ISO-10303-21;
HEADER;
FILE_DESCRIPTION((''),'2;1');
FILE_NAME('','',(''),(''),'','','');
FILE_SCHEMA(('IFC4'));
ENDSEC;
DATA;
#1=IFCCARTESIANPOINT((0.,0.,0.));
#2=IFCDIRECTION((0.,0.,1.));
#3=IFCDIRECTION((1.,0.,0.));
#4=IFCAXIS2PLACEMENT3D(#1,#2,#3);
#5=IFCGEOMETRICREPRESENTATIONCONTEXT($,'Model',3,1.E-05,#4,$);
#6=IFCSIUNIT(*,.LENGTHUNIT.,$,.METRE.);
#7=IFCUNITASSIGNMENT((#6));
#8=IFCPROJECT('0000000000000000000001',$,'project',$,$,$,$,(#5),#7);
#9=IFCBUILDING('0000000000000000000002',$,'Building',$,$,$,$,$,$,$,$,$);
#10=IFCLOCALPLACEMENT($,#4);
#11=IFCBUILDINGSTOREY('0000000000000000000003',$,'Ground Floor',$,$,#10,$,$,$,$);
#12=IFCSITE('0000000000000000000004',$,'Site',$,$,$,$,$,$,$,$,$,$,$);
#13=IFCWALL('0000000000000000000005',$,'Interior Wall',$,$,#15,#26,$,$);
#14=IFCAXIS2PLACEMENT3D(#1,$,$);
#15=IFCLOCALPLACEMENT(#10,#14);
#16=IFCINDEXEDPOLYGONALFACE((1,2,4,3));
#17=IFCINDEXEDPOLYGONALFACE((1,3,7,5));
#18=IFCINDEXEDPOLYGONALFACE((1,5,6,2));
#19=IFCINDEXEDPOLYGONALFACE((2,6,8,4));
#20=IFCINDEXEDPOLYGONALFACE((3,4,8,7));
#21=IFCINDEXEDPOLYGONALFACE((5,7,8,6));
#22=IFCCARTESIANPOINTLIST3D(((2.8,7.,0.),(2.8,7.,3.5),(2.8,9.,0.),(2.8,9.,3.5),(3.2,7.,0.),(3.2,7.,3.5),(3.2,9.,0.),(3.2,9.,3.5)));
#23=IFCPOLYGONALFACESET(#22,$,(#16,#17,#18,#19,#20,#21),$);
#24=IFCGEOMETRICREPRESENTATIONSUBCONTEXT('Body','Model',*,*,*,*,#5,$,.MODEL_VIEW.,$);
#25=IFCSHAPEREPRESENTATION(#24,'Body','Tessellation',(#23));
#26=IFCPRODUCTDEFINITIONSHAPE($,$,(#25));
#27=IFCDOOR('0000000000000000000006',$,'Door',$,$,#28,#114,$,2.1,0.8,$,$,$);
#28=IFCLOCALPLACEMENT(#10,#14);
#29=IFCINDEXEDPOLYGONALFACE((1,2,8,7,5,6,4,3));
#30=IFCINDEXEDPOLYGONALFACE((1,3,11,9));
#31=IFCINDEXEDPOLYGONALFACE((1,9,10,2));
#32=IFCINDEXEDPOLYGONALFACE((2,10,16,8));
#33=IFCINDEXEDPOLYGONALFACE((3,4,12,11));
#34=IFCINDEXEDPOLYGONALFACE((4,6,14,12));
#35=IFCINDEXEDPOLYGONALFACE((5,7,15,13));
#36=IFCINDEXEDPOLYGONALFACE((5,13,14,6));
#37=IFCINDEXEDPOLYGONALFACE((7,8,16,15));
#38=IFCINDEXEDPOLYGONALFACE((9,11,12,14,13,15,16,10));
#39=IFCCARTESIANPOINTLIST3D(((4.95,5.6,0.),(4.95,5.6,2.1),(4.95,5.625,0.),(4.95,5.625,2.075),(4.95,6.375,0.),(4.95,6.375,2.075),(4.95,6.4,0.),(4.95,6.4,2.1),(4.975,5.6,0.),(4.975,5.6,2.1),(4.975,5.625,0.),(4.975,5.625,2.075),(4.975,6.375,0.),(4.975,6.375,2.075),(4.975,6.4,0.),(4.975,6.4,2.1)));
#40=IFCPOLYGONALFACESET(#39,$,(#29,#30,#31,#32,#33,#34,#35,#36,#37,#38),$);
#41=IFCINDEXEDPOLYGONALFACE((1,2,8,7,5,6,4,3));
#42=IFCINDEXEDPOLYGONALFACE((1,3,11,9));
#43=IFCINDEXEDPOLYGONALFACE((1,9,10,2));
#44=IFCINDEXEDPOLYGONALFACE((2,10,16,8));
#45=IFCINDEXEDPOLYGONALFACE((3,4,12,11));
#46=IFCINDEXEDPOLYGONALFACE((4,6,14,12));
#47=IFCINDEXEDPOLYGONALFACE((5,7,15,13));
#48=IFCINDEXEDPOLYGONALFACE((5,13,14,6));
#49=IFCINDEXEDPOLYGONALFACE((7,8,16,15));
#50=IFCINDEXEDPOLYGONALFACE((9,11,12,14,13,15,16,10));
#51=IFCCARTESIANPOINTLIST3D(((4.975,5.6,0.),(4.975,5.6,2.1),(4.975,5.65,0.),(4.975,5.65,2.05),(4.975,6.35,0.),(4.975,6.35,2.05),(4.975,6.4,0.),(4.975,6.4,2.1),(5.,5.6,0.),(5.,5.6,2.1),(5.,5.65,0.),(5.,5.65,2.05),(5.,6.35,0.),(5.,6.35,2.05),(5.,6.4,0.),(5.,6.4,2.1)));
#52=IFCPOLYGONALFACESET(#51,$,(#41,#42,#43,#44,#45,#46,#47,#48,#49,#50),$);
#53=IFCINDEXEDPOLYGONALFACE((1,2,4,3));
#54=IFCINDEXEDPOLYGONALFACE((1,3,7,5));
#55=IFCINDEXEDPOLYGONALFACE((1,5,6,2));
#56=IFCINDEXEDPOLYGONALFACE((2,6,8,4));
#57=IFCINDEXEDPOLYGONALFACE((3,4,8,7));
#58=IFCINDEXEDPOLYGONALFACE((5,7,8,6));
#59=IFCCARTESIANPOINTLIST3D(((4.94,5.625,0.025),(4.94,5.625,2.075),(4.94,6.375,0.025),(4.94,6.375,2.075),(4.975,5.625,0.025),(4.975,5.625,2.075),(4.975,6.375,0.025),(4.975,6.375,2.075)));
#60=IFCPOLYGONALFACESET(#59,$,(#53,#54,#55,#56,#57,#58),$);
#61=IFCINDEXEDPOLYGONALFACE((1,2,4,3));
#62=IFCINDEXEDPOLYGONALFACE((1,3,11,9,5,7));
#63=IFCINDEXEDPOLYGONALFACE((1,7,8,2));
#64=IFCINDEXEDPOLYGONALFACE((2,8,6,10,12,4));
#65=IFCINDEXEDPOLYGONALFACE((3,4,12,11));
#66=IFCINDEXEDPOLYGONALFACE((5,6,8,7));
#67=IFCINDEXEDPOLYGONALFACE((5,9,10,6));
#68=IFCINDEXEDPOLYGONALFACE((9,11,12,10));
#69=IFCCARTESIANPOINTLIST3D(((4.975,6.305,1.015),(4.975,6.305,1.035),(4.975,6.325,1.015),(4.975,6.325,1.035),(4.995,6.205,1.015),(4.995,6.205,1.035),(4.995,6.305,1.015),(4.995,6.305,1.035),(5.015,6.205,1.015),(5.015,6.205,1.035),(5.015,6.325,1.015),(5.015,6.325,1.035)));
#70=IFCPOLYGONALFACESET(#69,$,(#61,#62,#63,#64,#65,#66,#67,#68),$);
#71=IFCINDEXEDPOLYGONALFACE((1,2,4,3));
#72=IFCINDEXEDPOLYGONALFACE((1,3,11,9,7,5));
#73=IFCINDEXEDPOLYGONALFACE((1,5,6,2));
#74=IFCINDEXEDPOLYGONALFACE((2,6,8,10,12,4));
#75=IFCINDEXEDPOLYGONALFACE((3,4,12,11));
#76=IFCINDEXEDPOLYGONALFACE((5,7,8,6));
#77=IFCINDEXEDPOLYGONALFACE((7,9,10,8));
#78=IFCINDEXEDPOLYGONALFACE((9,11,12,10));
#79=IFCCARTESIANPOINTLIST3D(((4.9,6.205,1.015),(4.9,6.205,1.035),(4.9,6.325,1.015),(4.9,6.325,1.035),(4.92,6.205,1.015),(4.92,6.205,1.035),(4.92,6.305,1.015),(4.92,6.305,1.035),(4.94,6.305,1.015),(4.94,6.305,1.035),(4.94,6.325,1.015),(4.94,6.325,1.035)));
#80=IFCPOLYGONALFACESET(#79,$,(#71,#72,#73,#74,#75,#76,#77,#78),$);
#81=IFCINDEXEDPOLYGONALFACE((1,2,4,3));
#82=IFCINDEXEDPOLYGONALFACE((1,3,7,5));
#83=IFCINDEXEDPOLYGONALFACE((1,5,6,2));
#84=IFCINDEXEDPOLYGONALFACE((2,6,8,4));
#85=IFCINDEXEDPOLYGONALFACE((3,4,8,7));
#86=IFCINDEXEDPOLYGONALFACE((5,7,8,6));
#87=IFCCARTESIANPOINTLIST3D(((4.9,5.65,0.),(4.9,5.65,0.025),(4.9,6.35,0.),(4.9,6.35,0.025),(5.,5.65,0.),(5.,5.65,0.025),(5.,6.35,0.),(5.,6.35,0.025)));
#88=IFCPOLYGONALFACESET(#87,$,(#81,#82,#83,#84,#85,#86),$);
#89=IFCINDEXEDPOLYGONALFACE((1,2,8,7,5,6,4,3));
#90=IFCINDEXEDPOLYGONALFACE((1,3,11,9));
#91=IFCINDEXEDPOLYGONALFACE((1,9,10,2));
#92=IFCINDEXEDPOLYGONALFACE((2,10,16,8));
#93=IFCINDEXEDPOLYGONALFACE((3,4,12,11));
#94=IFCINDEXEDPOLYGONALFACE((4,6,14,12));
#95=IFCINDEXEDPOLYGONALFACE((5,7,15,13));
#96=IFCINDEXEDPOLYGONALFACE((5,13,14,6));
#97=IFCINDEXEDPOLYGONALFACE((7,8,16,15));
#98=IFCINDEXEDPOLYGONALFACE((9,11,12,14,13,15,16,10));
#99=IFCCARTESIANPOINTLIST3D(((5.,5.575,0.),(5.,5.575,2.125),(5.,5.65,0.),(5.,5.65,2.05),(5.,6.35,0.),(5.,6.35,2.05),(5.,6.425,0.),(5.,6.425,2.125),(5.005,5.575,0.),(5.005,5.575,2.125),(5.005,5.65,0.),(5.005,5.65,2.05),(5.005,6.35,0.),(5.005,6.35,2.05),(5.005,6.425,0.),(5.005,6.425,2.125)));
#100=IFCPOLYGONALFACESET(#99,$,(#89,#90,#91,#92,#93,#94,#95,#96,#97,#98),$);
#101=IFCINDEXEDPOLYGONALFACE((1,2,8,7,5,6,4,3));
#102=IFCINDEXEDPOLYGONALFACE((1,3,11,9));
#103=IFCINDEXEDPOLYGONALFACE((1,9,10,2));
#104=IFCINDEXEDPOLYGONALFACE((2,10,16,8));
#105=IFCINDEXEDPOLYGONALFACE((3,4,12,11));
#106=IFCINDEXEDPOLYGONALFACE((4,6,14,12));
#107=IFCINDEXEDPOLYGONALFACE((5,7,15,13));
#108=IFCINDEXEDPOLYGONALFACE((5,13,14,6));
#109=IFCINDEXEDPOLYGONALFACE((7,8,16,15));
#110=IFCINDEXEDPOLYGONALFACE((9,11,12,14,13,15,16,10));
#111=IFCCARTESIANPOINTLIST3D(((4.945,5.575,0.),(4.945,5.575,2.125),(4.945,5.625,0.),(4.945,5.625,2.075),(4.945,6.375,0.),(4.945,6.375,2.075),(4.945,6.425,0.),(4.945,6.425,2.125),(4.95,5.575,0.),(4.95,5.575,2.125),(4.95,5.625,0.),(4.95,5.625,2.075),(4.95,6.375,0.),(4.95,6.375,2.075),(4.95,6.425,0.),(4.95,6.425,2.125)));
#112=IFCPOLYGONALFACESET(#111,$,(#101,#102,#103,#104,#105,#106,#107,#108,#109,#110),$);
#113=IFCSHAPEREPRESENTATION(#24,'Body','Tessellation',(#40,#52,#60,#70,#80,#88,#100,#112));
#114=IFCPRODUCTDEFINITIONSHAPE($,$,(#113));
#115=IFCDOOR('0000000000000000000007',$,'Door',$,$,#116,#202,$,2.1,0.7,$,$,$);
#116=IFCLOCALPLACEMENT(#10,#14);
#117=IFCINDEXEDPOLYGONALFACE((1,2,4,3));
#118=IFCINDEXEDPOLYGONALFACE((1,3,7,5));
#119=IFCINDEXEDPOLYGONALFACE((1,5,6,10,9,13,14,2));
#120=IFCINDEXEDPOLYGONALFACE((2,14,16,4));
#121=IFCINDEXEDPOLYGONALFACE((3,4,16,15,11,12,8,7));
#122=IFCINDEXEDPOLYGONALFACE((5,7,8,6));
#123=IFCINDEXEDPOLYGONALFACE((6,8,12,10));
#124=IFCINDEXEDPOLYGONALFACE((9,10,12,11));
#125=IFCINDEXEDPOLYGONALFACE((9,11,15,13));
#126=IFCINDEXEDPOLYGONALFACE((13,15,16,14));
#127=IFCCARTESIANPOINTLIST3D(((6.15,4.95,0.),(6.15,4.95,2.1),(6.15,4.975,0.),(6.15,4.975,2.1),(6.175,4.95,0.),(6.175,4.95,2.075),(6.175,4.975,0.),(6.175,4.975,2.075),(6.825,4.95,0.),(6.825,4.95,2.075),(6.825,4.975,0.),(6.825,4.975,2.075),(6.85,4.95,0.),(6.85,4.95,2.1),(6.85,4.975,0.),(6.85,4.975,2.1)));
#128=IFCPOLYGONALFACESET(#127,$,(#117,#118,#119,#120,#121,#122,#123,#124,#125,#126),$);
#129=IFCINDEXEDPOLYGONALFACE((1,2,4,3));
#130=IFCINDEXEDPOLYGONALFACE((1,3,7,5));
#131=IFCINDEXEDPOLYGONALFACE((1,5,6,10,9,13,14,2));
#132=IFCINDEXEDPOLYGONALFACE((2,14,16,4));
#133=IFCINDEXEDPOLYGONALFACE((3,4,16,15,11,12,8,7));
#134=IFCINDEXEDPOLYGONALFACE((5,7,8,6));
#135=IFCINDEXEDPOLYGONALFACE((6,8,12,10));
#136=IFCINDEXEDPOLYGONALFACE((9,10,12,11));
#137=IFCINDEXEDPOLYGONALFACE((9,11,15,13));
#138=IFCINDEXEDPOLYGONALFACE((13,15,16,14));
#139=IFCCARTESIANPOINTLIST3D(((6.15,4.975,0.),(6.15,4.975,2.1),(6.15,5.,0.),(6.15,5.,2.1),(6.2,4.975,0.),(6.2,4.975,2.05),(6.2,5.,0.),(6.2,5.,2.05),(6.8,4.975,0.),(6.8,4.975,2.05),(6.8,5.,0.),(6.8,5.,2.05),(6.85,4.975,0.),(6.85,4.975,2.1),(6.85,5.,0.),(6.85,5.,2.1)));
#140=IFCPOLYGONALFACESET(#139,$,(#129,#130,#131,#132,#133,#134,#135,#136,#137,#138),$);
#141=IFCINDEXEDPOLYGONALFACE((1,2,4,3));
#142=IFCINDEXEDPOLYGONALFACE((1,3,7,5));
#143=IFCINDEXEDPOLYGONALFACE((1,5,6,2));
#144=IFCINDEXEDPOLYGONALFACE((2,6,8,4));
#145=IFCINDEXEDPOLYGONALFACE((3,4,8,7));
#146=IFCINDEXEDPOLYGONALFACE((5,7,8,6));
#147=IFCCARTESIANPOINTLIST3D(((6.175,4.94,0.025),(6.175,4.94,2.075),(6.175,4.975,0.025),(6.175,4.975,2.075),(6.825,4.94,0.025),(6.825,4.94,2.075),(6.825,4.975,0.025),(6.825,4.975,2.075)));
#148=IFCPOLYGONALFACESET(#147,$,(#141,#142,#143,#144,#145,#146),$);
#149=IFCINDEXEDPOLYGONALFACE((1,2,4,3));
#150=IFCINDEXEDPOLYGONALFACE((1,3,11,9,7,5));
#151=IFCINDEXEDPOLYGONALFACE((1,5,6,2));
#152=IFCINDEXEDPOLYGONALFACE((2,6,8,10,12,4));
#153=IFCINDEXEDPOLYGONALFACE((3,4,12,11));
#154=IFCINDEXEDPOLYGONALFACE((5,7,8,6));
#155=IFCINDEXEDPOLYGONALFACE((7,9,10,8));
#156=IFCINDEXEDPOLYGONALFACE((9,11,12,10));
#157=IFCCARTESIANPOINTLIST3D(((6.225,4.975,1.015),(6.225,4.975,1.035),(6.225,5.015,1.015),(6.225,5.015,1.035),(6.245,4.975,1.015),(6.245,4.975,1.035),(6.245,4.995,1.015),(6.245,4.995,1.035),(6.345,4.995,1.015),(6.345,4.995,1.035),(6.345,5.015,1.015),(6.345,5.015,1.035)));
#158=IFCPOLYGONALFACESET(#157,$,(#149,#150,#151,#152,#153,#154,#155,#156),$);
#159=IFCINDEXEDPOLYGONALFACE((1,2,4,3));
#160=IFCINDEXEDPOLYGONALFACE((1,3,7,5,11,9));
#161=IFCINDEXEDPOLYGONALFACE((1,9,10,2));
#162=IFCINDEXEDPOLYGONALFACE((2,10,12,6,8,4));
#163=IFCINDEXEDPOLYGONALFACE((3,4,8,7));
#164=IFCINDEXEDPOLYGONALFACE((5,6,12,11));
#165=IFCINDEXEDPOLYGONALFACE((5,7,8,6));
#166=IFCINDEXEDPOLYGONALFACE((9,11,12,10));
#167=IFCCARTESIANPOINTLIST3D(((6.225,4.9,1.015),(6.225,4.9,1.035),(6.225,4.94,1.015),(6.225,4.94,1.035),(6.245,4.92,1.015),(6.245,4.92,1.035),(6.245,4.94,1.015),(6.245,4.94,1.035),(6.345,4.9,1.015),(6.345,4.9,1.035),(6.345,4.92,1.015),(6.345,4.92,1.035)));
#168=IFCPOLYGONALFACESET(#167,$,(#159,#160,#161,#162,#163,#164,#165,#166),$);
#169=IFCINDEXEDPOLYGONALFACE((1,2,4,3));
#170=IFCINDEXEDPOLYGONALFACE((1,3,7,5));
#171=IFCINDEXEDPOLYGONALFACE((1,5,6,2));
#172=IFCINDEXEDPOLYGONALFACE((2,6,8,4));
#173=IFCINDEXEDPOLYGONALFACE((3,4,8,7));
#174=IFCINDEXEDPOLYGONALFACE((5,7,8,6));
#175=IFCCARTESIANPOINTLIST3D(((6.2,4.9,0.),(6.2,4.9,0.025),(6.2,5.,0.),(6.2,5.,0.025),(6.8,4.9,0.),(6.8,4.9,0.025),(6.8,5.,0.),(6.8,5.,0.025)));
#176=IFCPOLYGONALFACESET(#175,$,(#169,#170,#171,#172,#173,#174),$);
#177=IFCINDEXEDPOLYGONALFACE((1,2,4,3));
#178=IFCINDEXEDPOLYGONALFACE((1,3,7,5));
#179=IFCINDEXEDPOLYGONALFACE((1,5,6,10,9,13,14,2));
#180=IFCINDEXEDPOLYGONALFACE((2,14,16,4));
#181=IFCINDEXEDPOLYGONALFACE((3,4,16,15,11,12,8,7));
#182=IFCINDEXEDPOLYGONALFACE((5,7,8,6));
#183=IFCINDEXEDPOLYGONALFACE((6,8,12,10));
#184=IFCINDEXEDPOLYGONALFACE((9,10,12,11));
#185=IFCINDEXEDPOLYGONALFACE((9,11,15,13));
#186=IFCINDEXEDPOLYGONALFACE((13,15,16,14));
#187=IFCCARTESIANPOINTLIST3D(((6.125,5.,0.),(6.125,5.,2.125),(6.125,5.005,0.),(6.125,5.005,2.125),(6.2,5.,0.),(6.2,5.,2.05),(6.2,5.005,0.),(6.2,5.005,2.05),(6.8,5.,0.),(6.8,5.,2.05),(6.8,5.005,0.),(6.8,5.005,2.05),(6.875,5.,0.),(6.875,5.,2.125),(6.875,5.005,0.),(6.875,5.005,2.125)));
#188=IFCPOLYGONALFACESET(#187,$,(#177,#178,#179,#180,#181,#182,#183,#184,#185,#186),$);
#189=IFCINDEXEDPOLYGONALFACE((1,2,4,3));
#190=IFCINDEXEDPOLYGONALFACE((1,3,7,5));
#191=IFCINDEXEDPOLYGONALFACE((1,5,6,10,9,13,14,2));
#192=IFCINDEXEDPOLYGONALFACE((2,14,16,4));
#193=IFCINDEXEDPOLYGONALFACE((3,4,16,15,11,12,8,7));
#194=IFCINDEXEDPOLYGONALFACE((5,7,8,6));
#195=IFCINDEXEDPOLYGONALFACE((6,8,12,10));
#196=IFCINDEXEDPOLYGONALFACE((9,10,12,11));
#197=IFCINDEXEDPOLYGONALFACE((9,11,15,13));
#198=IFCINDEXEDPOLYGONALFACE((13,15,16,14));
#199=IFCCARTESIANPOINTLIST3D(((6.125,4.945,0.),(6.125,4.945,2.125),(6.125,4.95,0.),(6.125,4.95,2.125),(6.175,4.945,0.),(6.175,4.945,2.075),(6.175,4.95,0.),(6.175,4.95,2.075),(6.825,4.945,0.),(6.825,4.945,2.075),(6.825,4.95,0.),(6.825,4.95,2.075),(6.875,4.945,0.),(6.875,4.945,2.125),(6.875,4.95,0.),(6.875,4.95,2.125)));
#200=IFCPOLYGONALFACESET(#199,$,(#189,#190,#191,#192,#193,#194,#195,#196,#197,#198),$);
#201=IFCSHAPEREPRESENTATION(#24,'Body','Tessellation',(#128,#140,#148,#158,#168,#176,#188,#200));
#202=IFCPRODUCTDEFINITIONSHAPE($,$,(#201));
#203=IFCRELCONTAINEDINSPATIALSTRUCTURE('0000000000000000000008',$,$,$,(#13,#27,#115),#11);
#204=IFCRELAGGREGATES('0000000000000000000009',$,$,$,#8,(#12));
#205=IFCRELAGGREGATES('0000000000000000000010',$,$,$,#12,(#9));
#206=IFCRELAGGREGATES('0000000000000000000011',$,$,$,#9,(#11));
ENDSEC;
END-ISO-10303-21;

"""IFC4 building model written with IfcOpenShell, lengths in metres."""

from ifc_helpers import new_model, si_unit, frame, origin_with_axes, place, context, subcontext, project, spatial, line, indexed_curve, outline, extrude, element, save


model = new_model("IFC4")

# Units and contexts
model_context = context("Model", 3, precision=1e-05, world=origin_with_axes())
body_context = subcontext(model_context, "Body", "Model", "MODEL_VIEW")
ifc_project = project(units=[si_unit("LENGTHUNIT", "METRE")], contexts=[model_context])

# Site, building, storey
site = spatial("IfcSite", under=ifc_project, Name="Site")
building = spatial("IfcBuilding", under=site, Name="Building")
storey_placement = place(None, origin_with_axes())
storey = spatial("IfcBuildingStorey", under=building, at=storey_placement, Name="Ground Floor")

# Wall
wall_1_placement = place(storey_placement, frame((3.0, 7.0, 0.0), z_axis=(0.0, 0.0, 1.0), x_axis=(0.0, 1.0, 0.0)))
element("IfcWall", 1, at=wall_1_placement, inside=storey, Name="Interior Wall", context=body_context, shape_type="SweptSolid", body=[
    extrude(outline(indexed_curve([(0.0, 0.0), (0.0, 0.4), (2.0, 0.4), (2.0, 0.0), (0.0, 0.0)], self_intersect=False)), frame((0.0, -0.2, 0.0), z_axis=(0.0, 0.0, 1.0), x_axis=(1.0, 0.0, 0.0)), (0.0, 0.0, 1.0), 3.5),
])

# Doors
door_1_placement = place(storey_placement, frame((5.0, 5.6, 0.0), z_axis=(0.0, 0.0, 1.0), x_axis=(0.0, 1.0, 0.0)))
element("IfcDoor", 2, at=door_1_placement, inside=storey, Name="Door", OverallHeight=2.1, OverallWidth=0.8, context=body_context, shape_type="SweptSolid", body=[
    extrude(outline(indexed_curve([(0.0, 0.0), (0.0, 2.1), (0.8, 2.1), (0.8, 0.0), (0.775, 0.0), (0.775, 2.075), (0.025, 2.075), (0.025, 0.0)], segments=[line(1, 2, 3, 4, 5, 6, 7, 8, 1)])), frame((0.0, 0.025, 0.0), z_axis=(0.0, -1.0, 0.0), x_axis=(1.0, 0.0, 0.0)), (0.0, 0.0, -1.0), 0.025),
    extrude(outline(indexed_curve([(0.0, 0.0), (0.0, 2.1), (0.8, 2.1), (0.8, 0.0), (0.75, 0.0), (0.75, 2.05), (0.05, 2.05), (0.05, 0.0)], segments=[line(1, 2, 3, 4, 5, 6, 7, 8, 1)])), frame((0.0, 0.0, 0.0), z_axis=(0.0, -1.0, 0.0), x_axis=(1.0, 0.0, 0.0)), (0.0, 0.0, -1.0), 0.025),
    extrude(outline(indexed_curve([(0.0, 0.0), (0.75, 0.0), (0.75, 0.035), (0.0, 0.035)], segments=[line(1, 2, 3, 4, 1)])), frame((0.025, 0.025, 0.025), z_axis=(0.0, 0.0, 1.0), x_axis=(1.0, 0.0, 0.0)), (0.0, 0.0, 1.0), 2.05),
    extrude(outline(indexed_curve([(0.0, 0.0), (0.0, -0.04), (-0.12, -0.04), (-0.12, -0.02), (-0.02, -0.02), (-0.02, 0.0)], segments=[line(1, 2, 3, 4, 5, 6, 1)])), frame((0.725, 0.025, 1.015), z_axis=(0.0, 0.0, 1.0), x_axis=(1.0, 0.0, 0.0)), (0.0, 0.0, 1.0), 0.02),
    extrude(outline(indexed_curve([(0.0, 0.0), (0.0, 0.04), (-0.12, 0.04), (-0.12, 0.02), (-0.02, 0.02), (-0.02, 0.0)], segments=[line(1, 2, 3, 4, 5, 6, 1)])), frame((0.725, 0.06, 1.015), z_axis=(0.0, 0.0, 1.0), x_axis=(1.0, 0.0, 0.0)), (0.0, 0.0, 1.0), 0.02),
    extrude(outline(indexed_curve([(0.0, 0.0), (0.7, 0.0), (0.7, 0.1), (0.0, 0.1)], segments=[line(1, 2, 3, 4, 1)])), frame((0.05, 0.0, 0.0), z_axis=(0.0, 0.0, 1.0), x_axis=(1.0, 0.0, 0.0)), (0.0, 0.0, 1.0), 0.025),
    extrude(outline(indexed_curve([(0.0, 0.0), (0.0, 2.125), (0.85, 2.125), (0.85, 0.0), (0.775, 0.0), (0.775, 2.05), (0.075, 2.05), (0.075, 0.0)], segments=[line(1, 2, 3, 4, 5, 6, 7, 8, 1)])), frame((-0.025, -0.005, 0.0), z_axis=(0.0, -1.0, 0.0), x_axis=(1.0, 0.0, 0.0)), (0.0, 0.0, -1.0), 0.005),
    extrude(outline(indexed_curve([(0.0, 0.0), (0.0, 2.125), (0.85, 2.125), (0.85, 0.0), (0.8, 0.0), (0.8, 2.075), (0.05, 2.075), (0.05, 0.0)], segments=[line(1, 2, 3, 4, 5, 6, 7, 8, 1)])), frame((-0.025, 0.05, 0.0), z_axis=(0.0, -1.0, 0.0), x_axis=(1.0, 0.0, 0.0)), (0.0, 0.0, -1.0), 0.005),
])
door_2_placement = place(storey_placement, frame((6.85, 5.0, 0.0), z_axis=(0.0, 0.0, 1.0), x_axis=(-1.0, 0.0, 0.0)))
element("IfcDoor", 3, at=door_2_placement, inside=storey, Name="Door", OverallHeight=2.1, OverallWidth=0.7, context=body_context, shape_type="SweptSolid", body=[
    extrude(outline(indexed_curve([(0.0, 0.0), (0.0, 2.1), (0.7, 2.1), (0.7, 0.0), (0.675, 0.0), (0.675, 2.075), (0.025, 2.075), (0.025, 0.0)], segments=[line(1, 2, 3, 4, 5, 6, 7, 8, 1)])), frame((0.0, 0.025, 0.0), z_axis=(0.0, -1.0, 0.0), x_axis=(1.0, 0.0, 0.0)), (0.0, 0.0, -1.0), 0.025),
    extrude(outline(indexed_curve([(0.0, 0.0), (0.0, 2.1), (0.7, 2.1), (0.7, 0.0), (0.65, 0.0), (0.65, 2.05), (0.05, 2.05), (0.05, 0.0)], segments=[line(1, 2, 3, 4, 5, 6, 7, 8, 1)])), frame((0.0, 0.0, 0.0), z_axis=(0.0, -1.0, 0.0), x_axis=(1.0, 0.0, 0.0)), (0.0, 0.0, -1.0), 0.025),
    extrude(outline(indexed_curve([(0.0, 0.0), (0.65, 0.0), (0.65, 0.035), (0.0, 0.035)], segments=[line(1, 2, 3, 4, 1)])), frame((0.025, 0.025, 0.025), z_axis=(0.0, 0.0, 1.0), x_axis=(1.0, 0.0, 0.0)), (0.0, 0.0, 1.0), 2.05),
    extrude(outline(indexed_curve([(0.0, 0.0), (0.0, -0.04), (-0.12, -0.04), (-0.12, -0.02), (-0.02, -0.02), (-0.02, 0.0)], segments=[line(1, 2, 3, 4, 5, 6, 1)])), frame((0.625, 0.025, 1.015), z_axis=(0.0, 0.0, 1.0), x_axis=(1.0, 0.0, 0.0)), (0.0, 0.0, 1.0), 0.02),
    extrude(outline(indexed_curve([(0.0, 0.0), (0.0, 0.04), (-0.12, 0.04), (-0.12, 0.02), (-0.02, 0.02), (-0.02, 0.0)], segments=[line(1, 2, 3, 4, 5, 6, 1)])), frame((0.625, 0.06, 1.015), z_axis=(0.0, 0.0, 1.0), x_axis=(1.0, 0.0, 0.0)), (0.0, 0.0, 1.0), 0.02),
    extrude(outline(indexed_curve([(0.0, 0.0), (0.6, 0.0), (0.6, 0.1), (0.0, 0.1)], segments=[line(1, 2, 3, 4, 1)])), frame((0.05, 0.0, 0.0), z_axis=(0.0, 0.0, 1.0), x_axis=(1.0, 0.0, 0.0)), (0.0, 0.0, 1.0), 0.025),
    extrude(outline(indexed_curve([(0.0, 0.0), (0.0, 2.125), (0.75, 2.125), (0.75, 0.0), (0.675, 0.0), (0.675, 2.05), (0.075, 2.05), (0.075, 0.0)], segments=[line(1, 2, 3, 4, 5, 6, 7, 8, 1)])), frame((-0.025, -0.005, 0.0), z_axis=(0.0, -1.0, 0.0), x_axis=(1.0, 0.0, 0.0)), (0.0, 0.0, -1.0), 0.005),
    extrude(outline(indexed_curve([(0.0, 0.0), (0.0, 2.125), (0.75, 2.125), (0.75, 0.0), (0.7, 0.0), (0.7, 2.075), (0.05, 2.075), (0.05, 0.0)], segments=[line(1, 2, 3, 4, 5, 6, 7, 8, 1)])), frame((-0.025, 0.05, 0.0), z_axis=(0.0, -1.0, 0.0), x_axis=(1.0, 0.0, 0.0)), (0.0, 0.0, -1.0), 0.005),
])

save(model, "model.ifc")
